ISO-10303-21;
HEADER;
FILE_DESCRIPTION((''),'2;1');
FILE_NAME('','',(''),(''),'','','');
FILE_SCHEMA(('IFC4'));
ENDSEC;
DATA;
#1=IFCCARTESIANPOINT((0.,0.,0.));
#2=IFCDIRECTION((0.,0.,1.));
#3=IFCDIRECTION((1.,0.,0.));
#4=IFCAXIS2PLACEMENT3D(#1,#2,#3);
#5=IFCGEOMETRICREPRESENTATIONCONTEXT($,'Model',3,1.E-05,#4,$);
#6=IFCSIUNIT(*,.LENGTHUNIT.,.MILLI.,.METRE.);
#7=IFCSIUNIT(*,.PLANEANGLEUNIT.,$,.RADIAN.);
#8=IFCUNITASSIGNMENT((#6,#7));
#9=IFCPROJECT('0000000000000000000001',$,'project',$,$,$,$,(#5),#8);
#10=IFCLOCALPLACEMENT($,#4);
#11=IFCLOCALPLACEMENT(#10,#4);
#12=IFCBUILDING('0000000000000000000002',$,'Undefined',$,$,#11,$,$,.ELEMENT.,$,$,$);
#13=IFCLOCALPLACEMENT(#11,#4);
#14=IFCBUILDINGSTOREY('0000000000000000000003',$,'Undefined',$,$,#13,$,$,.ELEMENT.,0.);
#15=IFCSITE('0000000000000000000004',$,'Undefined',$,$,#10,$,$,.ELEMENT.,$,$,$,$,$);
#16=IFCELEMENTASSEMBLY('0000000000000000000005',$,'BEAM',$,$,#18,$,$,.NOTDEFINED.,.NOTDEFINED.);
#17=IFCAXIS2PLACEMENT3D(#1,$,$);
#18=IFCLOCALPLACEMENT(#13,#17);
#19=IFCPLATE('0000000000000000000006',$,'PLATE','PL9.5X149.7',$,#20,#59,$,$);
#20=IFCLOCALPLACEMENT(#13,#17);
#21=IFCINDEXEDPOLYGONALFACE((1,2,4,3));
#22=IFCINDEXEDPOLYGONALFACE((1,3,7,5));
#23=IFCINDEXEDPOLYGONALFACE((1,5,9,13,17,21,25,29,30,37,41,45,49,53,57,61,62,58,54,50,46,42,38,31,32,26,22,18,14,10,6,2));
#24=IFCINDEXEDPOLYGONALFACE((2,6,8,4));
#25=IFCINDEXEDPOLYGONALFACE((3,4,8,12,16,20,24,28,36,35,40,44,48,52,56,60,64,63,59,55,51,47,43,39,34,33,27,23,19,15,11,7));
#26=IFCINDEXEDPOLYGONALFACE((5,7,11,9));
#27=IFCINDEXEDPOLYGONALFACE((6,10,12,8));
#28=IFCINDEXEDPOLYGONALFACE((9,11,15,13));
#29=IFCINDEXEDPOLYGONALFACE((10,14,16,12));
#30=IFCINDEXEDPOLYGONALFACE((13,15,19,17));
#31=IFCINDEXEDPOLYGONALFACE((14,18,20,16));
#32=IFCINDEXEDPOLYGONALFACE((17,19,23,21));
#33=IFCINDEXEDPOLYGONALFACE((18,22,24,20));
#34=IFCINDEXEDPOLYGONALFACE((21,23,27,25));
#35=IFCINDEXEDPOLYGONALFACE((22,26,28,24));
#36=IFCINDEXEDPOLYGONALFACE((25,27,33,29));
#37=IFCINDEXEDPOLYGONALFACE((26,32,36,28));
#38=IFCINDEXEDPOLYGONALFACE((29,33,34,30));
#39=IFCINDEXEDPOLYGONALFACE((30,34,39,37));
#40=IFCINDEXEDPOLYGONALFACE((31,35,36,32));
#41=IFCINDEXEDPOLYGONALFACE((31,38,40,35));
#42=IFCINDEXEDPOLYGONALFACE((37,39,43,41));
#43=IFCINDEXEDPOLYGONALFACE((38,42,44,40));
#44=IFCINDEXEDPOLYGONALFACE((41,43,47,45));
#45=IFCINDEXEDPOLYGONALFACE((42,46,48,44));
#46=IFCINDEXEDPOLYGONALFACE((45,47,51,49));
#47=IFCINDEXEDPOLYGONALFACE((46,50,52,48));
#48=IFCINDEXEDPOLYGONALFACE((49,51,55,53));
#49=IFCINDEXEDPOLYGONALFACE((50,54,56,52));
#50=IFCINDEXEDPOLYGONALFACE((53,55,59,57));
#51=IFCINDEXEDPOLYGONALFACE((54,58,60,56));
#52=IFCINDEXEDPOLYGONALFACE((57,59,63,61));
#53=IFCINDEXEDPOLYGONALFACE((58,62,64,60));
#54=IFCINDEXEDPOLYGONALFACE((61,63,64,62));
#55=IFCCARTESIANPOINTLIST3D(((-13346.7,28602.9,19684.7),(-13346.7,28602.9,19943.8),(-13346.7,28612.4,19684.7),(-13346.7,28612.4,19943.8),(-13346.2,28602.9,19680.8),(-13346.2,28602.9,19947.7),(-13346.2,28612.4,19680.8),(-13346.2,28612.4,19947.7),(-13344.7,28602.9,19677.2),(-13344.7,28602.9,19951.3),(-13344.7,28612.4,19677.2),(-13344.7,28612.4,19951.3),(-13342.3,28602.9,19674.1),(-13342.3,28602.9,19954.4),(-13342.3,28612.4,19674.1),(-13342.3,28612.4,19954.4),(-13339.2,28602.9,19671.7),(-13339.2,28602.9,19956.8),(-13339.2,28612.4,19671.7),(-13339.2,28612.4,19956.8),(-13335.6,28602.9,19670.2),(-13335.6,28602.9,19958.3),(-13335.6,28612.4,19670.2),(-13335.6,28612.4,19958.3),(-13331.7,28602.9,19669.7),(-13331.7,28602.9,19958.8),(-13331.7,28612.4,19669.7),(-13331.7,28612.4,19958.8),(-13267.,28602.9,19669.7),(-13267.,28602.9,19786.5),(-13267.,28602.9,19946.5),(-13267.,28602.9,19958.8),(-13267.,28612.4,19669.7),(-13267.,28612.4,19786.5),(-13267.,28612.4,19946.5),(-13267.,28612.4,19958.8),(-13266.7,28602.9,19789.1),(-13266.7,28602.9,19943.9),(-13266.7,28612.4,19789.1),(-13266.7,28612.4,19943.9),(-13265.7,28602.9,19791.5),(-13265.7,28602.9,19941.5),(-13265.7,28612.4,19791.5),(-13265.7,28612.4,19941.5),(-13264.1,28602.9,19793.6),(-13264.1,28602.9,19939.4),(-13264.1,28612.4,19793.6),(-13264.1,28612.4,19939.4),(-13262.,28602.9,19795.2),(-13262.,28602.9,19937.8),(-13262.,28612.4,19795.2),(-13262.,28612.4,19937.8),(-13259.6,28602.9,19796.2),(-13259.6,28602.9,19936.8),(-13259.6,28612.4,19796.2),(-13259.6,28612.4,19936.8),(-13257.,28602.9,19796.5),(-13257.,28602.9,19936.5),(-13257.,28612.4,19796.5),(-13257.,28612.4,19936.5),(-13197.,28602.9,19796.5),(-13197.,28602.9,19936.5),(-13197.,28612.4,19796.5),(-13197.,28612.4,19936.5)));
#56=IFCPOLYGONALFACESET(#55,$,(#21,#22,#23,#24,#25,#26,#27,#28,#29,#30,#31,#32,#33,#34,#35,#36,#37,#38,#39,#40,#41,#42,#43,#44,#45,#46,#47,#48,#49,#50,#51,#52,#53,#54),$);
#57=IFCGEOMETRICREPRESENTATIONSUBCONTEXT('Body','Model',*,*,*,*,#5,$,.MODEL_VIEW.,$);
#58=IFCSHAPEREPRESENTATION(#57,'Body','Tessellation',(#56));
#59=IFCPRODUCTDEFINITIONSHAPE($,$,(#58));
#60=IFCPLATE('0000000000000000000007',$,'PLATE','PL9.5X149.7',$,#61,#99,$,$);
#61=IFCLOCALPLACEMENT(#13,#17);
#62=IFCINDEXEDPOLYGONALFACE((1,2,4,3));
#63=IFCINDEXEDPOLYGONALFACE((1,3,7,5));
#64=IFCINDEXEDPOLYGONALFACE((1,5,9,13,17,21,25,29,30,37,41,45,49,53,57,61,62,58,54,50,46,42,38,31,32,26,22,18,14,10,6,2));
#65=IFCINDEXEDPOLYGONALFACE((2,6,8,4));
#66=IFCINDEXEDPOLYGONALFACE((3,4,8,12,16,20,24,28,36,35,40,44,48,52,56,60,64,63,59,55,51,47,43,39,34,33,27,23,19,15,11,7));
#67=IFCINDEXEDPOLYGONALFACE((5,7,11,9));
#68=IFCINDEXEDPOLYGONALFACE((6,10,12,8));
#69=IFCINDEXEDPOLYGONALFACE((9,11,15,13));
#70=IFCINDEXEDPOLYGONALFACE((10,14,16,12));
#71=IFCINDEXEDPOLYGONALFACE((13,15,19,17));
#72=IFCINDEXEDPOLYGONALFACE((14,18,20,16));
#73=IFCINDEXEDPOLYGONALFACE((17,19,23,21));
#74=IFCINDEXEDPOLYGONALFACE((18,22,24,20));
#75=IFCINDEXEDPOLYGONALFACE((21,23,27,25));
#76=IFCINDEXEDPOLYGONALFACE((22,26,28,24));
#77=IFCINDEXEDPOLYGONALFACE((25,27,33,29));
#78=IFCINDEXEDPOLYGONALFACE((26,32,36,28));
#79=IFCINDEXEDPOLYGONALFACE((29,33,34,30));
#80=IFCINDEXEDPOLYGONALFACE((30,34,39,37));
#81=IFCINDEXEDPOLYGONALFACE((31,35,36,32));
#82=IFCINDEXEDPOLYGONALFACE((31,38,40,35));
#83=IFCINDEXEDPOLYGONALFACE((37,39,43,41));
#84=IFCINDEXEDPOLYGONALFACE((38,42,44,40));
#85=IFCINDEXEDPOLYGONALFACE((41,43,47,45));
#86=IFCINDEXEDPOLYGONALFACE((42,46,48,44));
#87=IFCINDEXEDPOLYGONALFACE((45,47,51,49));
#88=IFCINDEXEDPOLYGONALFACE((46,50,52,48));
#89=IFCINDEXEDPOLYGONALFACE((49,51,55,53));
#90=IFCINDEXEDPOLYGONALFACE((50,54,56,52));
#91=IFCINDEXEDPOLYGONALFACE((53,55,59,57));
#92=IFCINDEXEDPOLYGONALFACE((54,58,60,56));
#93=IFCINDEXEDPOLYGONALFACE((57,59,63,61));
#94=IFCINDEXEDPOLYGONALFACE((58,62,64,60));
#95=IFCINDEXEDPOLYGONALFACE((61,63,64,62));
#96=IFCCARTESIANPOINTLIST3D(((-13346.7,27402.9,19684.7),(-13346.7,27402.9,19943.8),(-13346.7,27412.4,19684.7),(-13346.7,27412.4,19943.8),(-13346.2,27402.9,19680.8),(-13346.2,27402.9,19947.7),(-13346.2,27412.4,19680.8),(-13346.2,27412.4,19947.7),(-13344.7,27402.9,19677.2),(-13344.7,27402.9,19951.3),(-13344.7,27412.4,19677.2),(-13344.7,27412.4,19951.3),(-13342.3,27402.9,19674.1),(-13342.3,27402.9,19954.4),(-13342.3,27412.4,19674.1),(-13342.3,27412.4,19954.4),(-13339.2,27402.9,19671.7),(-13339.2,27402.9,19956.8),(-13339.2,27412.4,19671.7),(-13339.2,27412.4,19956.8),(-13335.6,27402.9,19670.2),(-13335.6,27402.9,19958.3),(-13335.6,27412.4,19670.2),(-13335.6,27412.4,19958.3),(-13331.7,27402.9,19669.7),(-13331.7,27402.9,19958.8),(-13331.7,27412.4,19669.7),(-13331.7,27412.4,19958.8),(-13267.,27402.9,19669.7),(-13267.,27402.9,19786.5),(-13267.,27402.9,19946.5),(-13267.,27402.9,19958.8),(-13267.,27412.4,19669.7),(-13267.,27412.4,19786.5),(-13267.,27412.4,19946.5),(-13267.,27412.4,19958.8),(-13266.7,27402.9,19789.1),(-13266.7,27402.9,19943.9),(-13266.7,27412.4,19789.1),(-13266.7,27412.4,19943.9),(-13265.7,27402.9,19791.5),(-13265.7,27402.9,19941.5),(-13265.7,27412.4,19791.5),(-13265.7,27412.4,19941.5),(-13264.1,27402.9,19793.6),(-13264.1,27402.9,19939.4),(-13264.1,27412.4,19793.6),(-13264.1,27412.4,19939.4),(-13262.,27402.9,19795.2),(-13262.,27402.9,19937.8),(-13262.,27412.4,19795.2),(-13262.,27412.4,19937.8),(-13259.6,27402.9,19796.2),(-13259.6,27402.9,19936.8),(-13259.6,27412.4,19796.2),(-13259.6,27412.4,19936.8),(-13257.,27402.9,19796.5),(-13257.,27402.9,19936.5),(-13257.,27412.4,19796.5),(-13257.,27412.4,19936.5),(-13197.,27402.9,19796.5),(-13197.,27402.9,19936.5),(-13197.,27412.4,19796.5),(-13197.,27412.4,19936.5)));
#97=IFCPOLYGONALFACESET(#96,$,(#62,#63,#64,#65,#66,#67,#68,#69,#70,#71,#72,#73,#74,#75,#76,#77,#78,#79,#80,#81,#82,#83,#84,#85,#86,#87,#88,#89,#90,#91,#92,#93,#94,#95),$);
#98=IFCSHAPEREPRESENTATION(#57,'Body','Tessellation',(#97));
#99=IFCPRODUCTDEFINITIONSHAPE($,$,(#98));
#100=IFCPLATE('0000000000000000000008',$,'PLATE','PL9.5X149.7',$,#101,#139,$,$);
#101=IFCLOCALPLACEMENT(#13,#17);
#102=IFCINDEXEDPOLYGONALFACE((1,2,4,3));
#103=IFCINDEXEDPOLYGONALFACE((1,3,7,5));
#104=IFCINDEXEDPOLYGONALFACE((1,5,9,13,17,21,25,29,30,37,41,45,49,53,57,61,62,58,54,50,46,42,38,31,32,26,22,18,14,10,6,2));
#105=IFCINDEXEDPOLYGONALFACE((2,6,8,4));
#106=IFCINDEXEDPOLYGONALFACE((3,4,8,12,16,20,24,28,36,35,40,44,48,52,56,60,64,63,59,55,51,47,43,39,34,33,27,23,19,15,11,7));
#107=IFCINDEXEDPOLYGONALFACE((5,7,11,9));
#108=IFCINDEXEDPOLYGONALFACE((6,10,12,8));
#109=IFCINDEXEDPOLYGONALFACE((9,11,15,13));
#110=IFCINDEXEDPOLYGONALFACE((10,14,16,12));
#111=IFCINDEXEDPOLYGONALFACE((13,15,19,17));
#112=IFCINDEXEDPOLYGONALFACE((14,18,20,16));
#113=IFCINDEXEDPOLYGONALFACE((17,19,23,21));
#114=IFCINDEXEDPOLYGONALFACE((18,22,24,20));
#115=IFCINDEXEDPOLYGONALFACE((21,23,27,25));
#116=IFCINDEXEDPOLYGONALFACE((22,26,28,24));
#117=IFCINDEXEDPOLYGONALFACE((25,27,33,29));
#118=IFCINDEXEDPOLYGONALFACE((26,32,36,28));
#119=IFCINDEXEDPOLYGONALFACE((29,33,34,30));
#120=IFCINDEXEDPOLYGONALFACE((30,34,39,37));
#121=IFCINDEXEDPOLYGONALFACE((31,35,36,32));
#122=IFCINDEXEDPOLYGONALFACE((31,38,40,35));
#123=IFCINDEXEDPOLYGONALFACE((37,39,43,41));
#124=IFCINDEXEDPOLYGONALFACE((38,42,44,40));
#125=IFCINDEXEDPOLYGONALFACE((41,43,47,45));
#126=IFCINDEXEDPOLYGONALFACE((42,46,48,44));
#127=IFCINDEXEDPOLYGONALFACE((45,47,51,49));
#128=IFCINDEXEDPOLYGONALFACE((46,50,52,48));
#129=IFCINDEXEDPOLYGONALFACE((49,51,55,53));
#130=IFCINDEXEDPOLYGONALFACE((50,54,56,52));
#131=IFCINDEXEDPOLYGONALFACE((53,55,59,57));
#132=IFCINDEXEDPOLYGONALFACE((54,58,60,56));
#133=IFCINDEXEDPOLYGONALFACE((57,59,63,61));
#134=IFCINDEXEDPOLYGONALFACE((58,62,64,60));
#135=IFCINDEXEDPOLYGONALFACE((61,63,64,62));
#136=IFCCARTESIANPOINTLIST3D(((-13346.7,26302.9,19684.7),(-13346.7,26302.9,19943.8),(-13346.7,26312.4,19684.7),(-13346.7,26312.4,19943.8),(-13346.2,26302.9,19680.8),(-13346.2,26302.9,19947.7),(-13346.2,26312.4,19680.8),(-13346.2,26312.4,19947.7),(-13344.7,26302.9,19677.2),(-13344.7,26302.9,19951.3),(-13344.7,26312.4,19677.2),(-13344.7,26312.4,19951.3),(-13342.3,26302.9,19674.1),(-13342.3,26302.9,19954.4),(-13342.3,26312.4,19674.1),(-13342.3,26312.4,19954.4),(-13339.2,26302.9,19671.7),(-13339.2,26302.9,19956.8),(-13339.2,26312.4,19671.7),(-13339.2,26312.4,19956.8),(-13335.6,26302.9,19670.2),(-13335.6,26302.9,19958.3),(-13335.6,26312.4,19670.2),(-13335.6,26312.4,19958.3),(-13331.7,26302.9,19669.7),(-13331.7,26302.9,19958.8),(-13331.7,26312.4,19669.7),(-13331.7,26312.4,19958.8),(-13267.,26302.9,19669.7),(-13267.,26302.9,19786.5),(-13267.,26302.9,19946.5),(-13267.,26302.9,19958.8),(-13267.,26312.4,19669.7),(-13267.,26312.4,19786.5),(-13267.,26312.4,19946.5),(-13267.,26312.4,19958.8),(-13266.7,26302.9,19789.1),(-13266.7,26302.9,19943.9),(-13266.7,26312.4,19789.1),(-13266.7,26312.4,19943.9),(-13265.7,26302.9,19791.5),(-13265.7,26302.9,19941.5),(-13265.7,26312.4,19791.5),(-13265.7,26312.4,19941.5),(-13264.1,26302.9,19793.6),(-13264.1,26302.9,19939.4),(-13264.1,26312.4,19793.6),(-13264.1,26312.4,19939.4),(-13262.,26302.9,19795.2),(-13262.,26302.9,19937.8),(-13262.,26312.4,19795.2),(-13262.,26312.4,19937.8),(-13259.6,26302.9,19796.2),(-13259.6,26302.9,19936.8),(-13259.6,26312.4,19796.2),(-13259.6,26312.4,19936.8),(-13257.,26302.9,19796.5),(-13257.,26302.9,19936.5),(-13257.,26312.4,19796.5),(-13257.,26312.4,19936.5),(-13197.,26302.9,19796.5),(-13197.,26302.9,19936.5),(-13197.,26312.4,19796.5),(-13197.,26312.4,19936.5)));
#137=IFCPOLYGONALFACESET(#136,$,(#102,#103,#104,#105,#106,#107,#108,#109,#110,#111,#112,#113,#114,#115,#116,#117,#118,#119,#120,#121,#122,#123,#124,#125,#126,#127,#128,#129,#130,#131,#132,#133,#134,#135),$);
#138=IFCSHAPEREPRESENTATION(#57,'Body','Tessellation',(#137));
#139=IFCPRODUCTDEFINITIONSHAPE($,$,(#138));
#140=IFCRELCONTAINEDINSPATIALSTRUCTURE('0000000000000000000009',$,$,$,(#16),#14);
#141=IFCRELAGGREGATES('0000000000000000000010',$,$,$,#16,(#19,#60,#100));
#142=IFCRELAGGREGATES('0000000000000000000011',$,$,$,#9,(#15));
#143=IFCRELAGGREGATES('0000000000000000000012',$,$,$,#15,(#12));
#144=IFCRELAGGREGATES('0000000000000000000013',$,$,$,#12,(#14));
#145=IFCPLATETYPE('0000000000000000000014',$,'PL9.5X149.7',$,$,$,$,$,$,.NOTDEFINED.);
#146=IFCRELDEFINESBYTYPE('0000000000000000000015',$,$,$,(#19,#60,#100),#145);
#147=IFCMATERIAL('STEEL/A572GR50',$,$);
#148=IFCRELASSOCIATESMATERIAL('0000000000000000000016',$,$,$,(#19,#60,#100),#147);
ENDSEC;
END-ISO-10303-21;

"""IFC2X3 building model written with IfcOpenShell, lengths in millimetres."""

from ifc_helpers import new_model, si_unit, frame, frame_2d, origin_with_axes, place, context, subcontext, project, spatial, polyline, circle_curve, parameter, trimmed, segment, composite_curve, outline, extrude, material, type_object, element, aggregate, save


model = new_model("IFC2X3")

# Units and contexts
model_context = context("Model", 3, precision=1e-05, world=origin_with_axes())
body_context = subcontext(model_context, "Body", "Model", "MODEL_VIEW")
ifc_project = project(units=[si_unit("LENGTHUNIT", "METRE", prefix="MILLI"), si_unit("PLANEANGLEUNIT", "RADIAN")], contexts=[model_context])

# Site, building, storey
site_placement = place(None, origin_with_axes())
site = spatial("IfcSite", under=ifc_project, at=site_placement, Name="Undefined", CompositionType="ELEMENT")
building_placement = place(site_placement, origin_with_axes())
building = spatial("IfcBuilding", under=site, at=building_placement, Name="Undefined", CompositionType="ELEMENT")
storey_placement = place(building_placement, origin_with_axes())
storey = spatial("IfcBuildingStorey", under=building, at=storey_placement, Name="Undefined", CompositionType="ELEMENT", Elevation=0.0)

# Shared definitions
ifc_material_1 = material(Name="STEEL/A572GR50")

# Element assembly
assembly_1_placement = place(storey_placement, origin_with_axes())
assembly_1 = element("IfcElementAssembly", 1, at=assembly_1_placement, inside=storey, Name="BEAM", AssemblyPlace="NOTDEFINED", PredefinedType="NOTDEFINED")

# Plates
plate_type_1 = type_object("IfcPlateType", Name="PL9.5X149.7", PredefinedType="NOTDEFINED")
plate_1_placement = place(assembly_1_placement, frame((-13346.7, 28607.7, 19958.8), z_axis=(0.0, -1.0, 0.0), x_axis=(0.0, 0.0, -1.0)))
plate_1 = element("IfcPlate", 2, at=plate_1_placement, type_object=plate_type_1, material=ifc_material_1, Name="PLATE", Description="PL9.5X149.7", context=body_context, shape_type="SweptSolid", body=[
    extrude(outline(composite_curve([segment(trimmed(circle_curve(frame_2d((15.0, 15.0), x_axis=(-1.0, 0.0)), 15.0), [parameter(0.0)], [parameter(1.570796)], True, "PARAMETER"), True, "CONTINUOUS"), segment(polyline([(15.0, 0.0), (274.1, 0.0)]), True, "CONTINUOUS"), segment(trimmed(circle_curve(frame_2d((274.1, 15.0), x_axis=(0.0, -1.0)), 15.0), [parameter(0.0)], [parameter(1.570796)], True, "PARAMETER"), True, "CONTINUOUS"), segment(polyline([(289.1, 15.0), (289.1, 79.7), (172.3, 79.7)]), True, "CONTINUOUS"), segment(trimmed(circle_curve(frame_2d((172.3, 89.7), x_axis=(0.0, -1.0)), 10.0), [parameter(0.0)], [parameter(4.712389)], False, "PARAMETER"), True, "CONTINUOUS"), segment(polyline([(162.3, 89.7), (162.3, 149.7), (22.3, 149.7), (22.3, 89.7)]), True, "CONTINUOUS"), segment(trimmed(circle_curve(frame_2d((12.3, 89.7), x_axis=(1.0, 0.0)), 10.0), [parameter(0.0)], [parameter(4.712389)], False, "PARAMETER"), True, "CONTINUOUS"), segment(polyline([(12.3, 79.7), (0.0, 79.7), (0.0, 15.0)]), True, "CONTINUOUS")], self_intersect=True)), frame((0.0, 0.0, -4.8), z_axis=(0.0, 0.0, 1.0), x_axis=(1.0, 0.0, 0.0)), (0.0, 0.0, 1.0), 9.5),
])
plate_2_placement = place(assembly_1_placement, frame((-13346.7, 27407.7, 19958.8), z_axis=(0.0, -1.0, 0.0), x_axis=(0.0, 0.0, -1.0)))
plate_2 = element("IfcPlate", 3, at=plate_2_placement, type_object=plate_type_1, material=ifc_material_1, Name="PLATE", Description="PL9.5X149.7", context=body_context, shape_type="SweptSolid", body=[
    extrude(outline(composite_curve([segment(trimmed(circle_curve(frame_2d((15.0, 15.0), x_axis=(-1.0, 0.0)), 15.0), [parameter(0.0)], [parameter(1.570796)], True, "PARAMETER"), True, "CONTINUOUS"), segment(polyline([(15.0, 0.0), (274.1, 0.0)]), True, "CONTINUOUS"), segment(trimmed(circle_curve(frame_2d((274.1, 15.0), x_axis=(0.0, -1.0)), 15.0), [parameter(0.0)], [parameter(1.570796)], True, "PARAMETER"), True, "CONTINUOUS"), segment(polyline([(289.1, 15.0), (289.1, 79.7), (172.3, 79.7)]), True, "CONTINUOUS"), segment(trimmed(circle_curve(frame_2d((172.3, 89.7), x_axis=(0.0, -1.0)), 10.0), [parameter(0.0)], [parameter(4.712389)], False, "PARAMETER"), True, "CONTINUOUS"), segment(polyline([(162.3, 89.7), (162.3, 149.7), (22.3, 149.7), (22.3, 89.7)]), True, "CONTINUOUS"), segment(trimmed(circle_curve(frame_2d((12.3, 89.7), x_axis=(1.0, 0.0)), 10.0), [parameter(0.0)], [parameter(4.712389)], False, "PARAMETER"), True, "CONTINUOUS"), segment(polyline([(12.3, 79.7), (0.0, 79.7), (0.0, 15.0)]), True, "CONTINUOUS")], self_intersect=True)), frame((0.0, 0.0, -4.8), z_axis=(0.0, 0.0, 1.0), x_axis=(1.0, 0.0, 0.0)), (0.0, 0.0, 1.0), 9.5),
])
plate_3_placement = place(assembly_1_placement, frame((-13346.7, 26307.7, 19958.8), z_axis=(0.0, -1.0, 0.0), x_axis=(0.0, 0.0, -1.0)))
plate_3 = element("IfcPlate", 4, at=plate_3_placement, type_object=plate_type_1, material=ifc_material_1, Name="PLATE", Description="PL9.5X149.7", context=body_context, shape_type="SweptSolid", body=[
    extrude(outline(composite_curve([segment(trimmed(circle_curve(frame_2d((15.0, 15.0), x_axis=(-1.0, 0.0)), 15.0), [parameter(0.0)], [parameter(1.570796)], True, "PARAMETER"), True, "CONTINUOUS"), segment(polyline([(15.0, 0.0), (274.1, 0.0)]), True, "CONTINUOUS"), segment(trimmed(circle_curve(frame_2d((274.1, 15.0), x_axis=(0.0, -1.0)), 15.0), [parameter(0.0)], [parameter(1.570796)], True, "PARAMETER"), True, "CONTINUOUS"), segment(polyline([(289.1, 15.0), (289.1, 79.7), (172.3, 79.7)]), True, "CONTINUOUS"), segment(trimmed(circle_curve(frame_2d((172.3, 89.7), x_axis=(0.0, -1.0)), 10.0), [parameter(0.0)], [parameter(4.712389)], False, "PARAMETER"), True, "CONTINUOUS"), segment(polyline([(162.3, 89.7), (162.3, 149.7), (22.3, 149.7), (22.3, 89.7)]), True, "CONTINUOUS"), segment(trimmed(circle_curve(frame_2d((12.3, 89.7), x_axis=(1.0, 0.0)), 10.0), [parameter(0.0)], [parameter(4.712389)], False, "PARAMETER"), True, "CONTINUOUS"), segment(polyline([(12.3, 79.7), (0.0, 79.7), (0.0, 15.0)]), True, "CONTINUOUS")], self_intersect=True)), frame((0.0, 0.0, -4.8), z_axis=(0.0, 0.0, 1.0), x_axis=(1.0, 0.0, 0.0)), (0.0, 0.0, 1.0), 9.5),
])

aggregate(assembly_1, [plate_1, plate_2, plate_3])

save(model, "model.ifc")
